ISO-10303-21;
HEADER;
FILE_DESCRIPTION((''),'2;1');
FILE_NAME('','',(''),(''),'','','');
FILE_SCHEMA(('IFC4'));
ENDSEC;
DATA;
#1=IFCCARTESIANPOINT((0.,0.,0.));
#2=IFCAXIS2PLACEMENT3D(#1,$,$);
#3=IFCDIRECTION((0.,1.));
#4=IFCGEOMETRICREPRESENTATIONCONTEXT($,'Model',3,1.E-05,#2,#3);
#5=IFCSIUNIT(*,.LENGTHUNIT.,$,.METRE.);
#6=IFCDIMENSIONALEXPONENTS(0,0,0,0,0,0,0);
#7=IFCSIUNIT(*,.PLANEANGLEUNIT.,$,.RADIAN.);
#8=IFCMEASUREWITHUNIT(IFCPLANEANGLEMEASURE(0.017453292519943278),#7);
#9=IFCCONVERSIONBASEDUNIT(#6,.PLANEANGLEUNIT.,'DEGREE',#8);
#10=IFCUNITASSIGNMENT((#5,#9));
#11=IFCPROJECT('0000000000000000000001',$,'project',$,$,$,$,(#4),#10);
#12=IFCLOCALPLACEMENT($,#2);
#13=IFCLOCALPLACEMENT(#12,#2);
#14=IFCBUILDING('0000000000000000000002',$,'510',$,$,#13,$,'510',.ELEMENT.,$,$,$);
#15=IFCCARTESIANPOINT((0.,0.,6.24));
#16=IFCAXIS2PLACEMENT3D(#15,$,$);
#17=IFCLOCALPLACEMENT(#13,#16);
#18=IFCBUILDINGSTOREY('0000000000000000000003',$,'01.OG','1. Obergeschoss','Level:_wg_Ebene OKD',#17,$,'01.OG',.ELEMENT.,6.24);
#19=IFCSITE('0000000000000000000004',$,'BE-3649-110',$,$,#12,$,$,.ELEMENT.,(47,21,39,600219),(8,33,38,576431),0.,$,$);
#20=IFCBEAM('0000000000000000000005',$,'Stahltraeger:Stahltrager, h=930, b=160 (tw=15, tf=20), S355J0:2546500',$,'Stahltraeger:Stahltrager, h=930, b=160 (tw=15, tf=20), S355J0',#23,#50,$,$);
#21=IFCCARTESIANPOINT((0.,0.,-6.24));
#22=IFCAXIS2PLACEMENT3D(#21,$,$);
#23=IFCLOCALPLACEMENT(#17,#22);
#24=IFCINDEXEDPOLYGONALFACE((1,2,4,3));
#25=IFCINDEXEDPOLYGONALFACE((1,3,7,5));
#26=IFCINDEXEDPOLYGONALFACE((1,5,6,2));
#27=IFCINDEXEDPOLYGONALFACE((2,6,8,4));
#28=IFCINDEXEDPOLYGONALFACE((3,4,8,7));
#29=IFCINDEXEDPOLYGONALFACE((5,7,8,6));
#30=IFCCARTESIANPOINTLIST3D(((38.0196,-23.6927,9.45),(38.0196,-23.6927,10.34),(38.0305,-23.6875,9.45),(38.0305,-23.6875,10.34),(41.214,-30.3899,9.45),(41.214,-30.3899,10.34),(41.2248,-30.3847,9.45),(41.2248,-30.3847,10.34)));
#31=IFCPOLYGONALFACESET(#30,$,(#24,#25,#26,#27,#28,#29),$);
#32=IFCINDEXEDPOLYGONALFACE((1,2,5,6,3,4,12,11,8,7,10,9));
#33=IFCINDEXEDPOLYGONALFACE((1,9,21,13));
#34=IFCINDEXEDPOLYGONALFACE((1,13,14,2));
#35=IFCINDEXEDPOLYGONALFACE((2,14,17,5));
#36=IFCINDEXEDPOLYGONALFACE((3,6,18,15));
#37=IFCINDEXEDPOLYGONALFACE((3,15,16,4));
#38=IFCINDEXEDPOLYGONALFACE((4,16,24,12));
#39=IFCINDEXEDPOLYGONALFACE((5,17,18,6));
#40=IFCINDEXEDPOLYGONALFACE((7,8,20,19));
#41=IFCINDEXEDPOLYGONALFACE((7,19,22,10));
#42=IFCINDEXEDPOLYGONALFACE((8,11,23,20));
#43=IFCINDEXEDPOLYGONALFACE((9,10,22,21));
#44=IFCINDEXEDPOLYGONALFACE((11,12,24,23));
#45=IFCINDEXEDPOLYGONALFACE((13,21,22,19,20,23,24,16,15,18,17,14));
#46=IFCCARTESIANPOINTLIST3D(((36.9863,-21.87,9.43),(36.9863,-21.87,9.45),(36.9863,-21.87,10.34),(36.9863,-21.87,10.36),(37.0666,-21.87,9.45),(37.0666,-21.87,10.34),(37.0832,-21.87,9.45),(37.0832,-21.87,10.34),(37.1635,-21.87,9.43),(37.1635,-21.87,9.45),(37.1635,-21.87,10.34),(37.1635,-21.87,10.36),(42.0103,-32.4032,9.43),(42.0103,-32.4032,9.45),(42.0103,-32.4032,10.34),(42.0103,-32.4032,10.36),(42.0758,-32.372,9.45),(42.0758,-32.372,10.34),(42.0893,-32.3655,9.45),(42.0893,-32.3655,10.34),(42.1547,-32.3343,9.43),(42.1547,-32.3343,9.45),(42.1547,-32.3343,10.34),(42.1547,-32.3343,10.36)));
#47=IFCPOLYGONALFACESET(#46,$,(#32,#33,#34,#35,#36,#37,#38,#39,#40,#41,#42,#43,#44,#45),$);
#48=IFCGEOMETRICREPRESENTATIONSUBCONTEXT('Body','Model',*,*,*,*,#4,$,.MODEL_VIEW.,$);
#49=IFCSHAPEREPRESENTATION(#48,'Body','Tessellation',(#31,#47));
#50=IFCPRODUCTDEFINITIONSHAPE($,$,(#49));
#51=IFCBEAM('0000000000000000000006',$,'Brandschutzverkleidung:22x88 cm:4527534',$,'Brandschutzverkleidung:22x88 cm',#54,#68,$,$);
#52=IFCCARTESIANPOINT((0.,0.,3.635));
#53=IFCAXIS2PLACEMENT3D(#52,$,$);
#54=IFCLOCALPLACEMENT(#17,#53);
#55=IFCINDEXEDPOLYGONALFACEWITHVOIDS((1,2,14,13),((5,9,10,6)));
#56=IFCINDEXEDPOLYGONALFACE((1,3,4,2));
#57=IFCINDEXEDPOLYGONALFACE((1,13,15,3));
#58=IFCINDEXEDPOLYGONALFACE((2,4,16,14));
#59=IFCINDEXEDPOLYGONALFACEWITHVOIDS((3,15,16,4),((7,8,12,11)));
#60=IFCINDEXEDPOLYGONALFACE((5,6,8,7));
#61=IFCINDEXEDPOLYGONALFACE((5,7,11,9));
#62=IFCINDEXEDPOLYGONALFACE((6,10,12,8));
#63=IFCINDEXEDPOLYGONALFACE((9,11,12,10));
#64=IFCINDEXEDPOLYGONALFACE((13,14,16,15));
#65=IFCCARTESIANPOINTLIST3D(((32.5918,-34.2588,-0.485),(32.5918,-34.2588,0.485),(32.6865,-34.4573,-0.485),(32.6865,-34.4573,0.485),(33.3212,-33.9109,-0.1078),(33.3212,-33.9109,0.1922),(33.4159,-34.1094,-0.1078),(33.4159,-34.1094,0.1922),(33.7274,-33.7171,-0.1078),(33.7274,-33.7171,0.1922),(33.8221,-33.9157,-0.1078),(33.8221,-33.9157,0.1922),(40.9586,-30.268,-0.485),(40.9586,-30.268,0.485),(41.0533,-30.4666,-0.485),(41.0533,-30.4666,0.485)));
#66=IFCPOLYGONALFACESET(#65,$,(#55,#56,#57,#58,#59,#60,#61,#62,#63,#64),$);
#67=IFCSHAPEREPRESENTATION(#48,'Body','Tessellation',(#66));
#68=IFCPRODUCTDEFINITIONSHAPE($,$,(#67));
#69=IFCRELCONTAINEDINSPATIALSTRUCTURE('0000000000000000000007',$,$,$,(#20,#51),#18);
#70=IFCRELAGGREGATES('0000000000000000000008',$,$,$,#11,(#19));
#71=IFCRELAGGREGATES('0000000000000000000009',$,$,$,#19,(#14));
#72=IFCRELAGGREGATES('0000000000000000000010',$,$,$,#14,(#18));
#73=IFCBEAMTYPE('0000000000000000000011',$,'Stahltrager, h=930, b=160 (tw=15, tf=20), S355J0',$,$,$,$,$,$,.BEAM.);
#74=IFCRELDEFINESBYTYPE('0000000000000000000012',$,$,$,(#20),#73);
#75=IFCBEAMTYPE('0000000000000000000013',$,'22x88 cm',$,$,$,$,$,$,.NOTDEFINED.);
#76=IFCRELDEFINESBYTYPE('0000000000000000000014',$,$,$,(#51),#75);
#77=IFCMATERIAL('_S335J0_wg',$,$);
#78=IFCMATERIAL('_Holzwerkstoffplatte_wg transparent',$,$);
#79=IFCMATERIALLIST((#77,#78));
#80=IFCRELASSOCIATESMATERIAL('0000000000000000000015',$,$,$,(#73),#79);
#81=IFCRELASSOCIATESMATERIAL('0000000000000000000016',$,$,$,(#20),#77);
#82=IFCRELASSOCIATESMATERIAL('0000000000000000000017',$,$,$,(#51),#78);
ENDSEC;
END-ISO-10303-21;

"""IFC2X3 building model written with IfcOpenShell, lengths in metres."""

from ifc_helpers import new_model, entity, si_unit, converted_unit, direction, frame, frame_2d, origin, place, context, subcontext, project, spatial, polyline, rectangle, i_section, outline, extrude, clip, halfspace, source, transform, mapped, material, material_list, type_object, type_shapes, element, save


model = new_model("IFC2X3")

# Units and contexts
model_context = context("Model", 3, precision=1e-05, world=origin(), true_north=direction((0.0, 1.0)))
body_context = subcontext(model_context, "Body", "Model", "MODEL_VIEW")
ifc_project = project(units=[si_unit("LENGTHUNIT", "METRE"), converted_unit("PLANEANGLEUNIT", "DEGREE", entity("IfcPlaneAngleMeasure", 0.017453292519943278), si_unit("PLANEANGLEUNIT", "RADIAN"), dimensions=[0, 0, 0, 0, 0, 0, 0])], contexts=[model_context])

# Site, building, storey
site_placement = place(None, origin())
site = spatial("IfcSite", under=ifc_project, at=site_placement, Name="BE-3649-110", CompositionType="ELEMENT", RefLatitude=(47, 21, 39, 600219), RefLongitude=(8, 33, 38, 576431), RefElevation=0.0)
building_placement = place(site_placement, origin())
building = spatial("IfcBuilding", under=site, at=building_placement, Name="510", LongName="510", CompositionType="ELEMENT")
storey_placement = place(building_placement, frame((0.0, 0.0, 6.24)))
storey = spatial("IfcBuildingStorey", under=building, at=storey_placement, Name="01.OG", Description="1. Obergeschoss", ObjectType="Level:_wg_Ebene OKD", LongName="01.OG", CompositionType="ELEMENT", Elevation=6.24)

# Beams
ifc_material_1 = material(Name="_S335J0_wg")
ifc_material_2 = material(Name="_Holzwerkstoffplatte_wg transparent")
ifc_material_list = material_list([ifc_material_1, ifc_material_2])
beam_type_1 = type_object("IfcBeamType", Name="Stahltrager, h=930, b=160 (tw=15, tf=20), S355J0", PredefinedType="BEAM", material=ifc_material_list)
shared_shape_1 = source(origin(), body_context, "Body", "SweptSolid", [
    extrude(rectangle(XDim=0.89, YDim=0.012, at=frame_2d((0.0, 0.0), x_axis=(1.0, 0.0))), frame((38.025, -23.6901, 9.895), z_axis=(0.430511, -0.902585, 0.0), x_axis=(0.0, 0.0, -1.0)), (0.0, 0.0, 1.0), 7.42),
    clip(extrude(i_section(OverallWidth=0.16, OverallDepth=0.93, WebThickness=0.015, FlangeThickness=0.02, at=frame_2d((0.0, 0.0), x_axis=(0.0, 1.0))), frame((37.0585, -21.8356, 9.895), z_axis=(0.430511, -0.902585, 0.0), x_axis=(0.0, 0.0, -1.0)), (0.0, 0.0, 1.0), 11.67), halfspace(frame((37.73, -21.87, 10.78), z_axis=(0.0, 1.0, 0.0), x_axis=(1.0, 0.0, 0.0)), False)),
])
type_shapes(beam_type_1, [shared_shape_1])
beam_1_placement = place(storey_placement, frame((0.0, 0.0, -6.24)))
element("IfcBeam", 1, at=beam_1_placement, inside=storey, type_object=beam_type_1, material=ifc_material_1, Name="Stahltraeger:Stahltrager, h=930, b=160 (tw=15, tf=20), S355J0:2546500", ObjectType="Stahltraeger:Stahltrager, h=930, b=160 (tw=15, tf=20), S355J0", context=body_context, shape_type="MappedRepresentation", body=[
    mapped(shared_shape_1, transform((0.0, 0.0, 0.0), scale=1.0)),
])
beam_type_2 = type_object("IfcBeamType", Name="22x88 cm", PredefinedType="NOTDEFINED")
beam_2_placement = place(storey_placement, frame((0.0, 0.0, 3.635)))
element("IfcBeam", 2, at=beam_2_placement, inside=storey, type_object=beam_type_2, material=ifc_material_2, Name="Brandschutzverkleidung:22x88 cm:4527534", ObjectType="Brandschutzverkleidung:22x88 cm", context=body_context, shape_type="SweptSolid", body=[
    extrude(outline(polyline([(-4.635, -0.485), (4.6349, -0.485), (4.6349, 0.485), (-4.635, 0.485), (-4.635, -0.485)]), holes=[polyline([(3.3768, -0.1078), (3.3768, 0.1922), (3.8268, 0.1922), (3.8268, -0.1078), (3.3768, -0.1078)])]), frame((36.8699, -32.462, 0.0), z_axis=(-0.430511, 0.902585, 0.0), x_axis=(-0.902585, -0.430511, 0.0)), (0.0, 0.0, 1.0), 0.22),
])

save(model, "model.ifc")
